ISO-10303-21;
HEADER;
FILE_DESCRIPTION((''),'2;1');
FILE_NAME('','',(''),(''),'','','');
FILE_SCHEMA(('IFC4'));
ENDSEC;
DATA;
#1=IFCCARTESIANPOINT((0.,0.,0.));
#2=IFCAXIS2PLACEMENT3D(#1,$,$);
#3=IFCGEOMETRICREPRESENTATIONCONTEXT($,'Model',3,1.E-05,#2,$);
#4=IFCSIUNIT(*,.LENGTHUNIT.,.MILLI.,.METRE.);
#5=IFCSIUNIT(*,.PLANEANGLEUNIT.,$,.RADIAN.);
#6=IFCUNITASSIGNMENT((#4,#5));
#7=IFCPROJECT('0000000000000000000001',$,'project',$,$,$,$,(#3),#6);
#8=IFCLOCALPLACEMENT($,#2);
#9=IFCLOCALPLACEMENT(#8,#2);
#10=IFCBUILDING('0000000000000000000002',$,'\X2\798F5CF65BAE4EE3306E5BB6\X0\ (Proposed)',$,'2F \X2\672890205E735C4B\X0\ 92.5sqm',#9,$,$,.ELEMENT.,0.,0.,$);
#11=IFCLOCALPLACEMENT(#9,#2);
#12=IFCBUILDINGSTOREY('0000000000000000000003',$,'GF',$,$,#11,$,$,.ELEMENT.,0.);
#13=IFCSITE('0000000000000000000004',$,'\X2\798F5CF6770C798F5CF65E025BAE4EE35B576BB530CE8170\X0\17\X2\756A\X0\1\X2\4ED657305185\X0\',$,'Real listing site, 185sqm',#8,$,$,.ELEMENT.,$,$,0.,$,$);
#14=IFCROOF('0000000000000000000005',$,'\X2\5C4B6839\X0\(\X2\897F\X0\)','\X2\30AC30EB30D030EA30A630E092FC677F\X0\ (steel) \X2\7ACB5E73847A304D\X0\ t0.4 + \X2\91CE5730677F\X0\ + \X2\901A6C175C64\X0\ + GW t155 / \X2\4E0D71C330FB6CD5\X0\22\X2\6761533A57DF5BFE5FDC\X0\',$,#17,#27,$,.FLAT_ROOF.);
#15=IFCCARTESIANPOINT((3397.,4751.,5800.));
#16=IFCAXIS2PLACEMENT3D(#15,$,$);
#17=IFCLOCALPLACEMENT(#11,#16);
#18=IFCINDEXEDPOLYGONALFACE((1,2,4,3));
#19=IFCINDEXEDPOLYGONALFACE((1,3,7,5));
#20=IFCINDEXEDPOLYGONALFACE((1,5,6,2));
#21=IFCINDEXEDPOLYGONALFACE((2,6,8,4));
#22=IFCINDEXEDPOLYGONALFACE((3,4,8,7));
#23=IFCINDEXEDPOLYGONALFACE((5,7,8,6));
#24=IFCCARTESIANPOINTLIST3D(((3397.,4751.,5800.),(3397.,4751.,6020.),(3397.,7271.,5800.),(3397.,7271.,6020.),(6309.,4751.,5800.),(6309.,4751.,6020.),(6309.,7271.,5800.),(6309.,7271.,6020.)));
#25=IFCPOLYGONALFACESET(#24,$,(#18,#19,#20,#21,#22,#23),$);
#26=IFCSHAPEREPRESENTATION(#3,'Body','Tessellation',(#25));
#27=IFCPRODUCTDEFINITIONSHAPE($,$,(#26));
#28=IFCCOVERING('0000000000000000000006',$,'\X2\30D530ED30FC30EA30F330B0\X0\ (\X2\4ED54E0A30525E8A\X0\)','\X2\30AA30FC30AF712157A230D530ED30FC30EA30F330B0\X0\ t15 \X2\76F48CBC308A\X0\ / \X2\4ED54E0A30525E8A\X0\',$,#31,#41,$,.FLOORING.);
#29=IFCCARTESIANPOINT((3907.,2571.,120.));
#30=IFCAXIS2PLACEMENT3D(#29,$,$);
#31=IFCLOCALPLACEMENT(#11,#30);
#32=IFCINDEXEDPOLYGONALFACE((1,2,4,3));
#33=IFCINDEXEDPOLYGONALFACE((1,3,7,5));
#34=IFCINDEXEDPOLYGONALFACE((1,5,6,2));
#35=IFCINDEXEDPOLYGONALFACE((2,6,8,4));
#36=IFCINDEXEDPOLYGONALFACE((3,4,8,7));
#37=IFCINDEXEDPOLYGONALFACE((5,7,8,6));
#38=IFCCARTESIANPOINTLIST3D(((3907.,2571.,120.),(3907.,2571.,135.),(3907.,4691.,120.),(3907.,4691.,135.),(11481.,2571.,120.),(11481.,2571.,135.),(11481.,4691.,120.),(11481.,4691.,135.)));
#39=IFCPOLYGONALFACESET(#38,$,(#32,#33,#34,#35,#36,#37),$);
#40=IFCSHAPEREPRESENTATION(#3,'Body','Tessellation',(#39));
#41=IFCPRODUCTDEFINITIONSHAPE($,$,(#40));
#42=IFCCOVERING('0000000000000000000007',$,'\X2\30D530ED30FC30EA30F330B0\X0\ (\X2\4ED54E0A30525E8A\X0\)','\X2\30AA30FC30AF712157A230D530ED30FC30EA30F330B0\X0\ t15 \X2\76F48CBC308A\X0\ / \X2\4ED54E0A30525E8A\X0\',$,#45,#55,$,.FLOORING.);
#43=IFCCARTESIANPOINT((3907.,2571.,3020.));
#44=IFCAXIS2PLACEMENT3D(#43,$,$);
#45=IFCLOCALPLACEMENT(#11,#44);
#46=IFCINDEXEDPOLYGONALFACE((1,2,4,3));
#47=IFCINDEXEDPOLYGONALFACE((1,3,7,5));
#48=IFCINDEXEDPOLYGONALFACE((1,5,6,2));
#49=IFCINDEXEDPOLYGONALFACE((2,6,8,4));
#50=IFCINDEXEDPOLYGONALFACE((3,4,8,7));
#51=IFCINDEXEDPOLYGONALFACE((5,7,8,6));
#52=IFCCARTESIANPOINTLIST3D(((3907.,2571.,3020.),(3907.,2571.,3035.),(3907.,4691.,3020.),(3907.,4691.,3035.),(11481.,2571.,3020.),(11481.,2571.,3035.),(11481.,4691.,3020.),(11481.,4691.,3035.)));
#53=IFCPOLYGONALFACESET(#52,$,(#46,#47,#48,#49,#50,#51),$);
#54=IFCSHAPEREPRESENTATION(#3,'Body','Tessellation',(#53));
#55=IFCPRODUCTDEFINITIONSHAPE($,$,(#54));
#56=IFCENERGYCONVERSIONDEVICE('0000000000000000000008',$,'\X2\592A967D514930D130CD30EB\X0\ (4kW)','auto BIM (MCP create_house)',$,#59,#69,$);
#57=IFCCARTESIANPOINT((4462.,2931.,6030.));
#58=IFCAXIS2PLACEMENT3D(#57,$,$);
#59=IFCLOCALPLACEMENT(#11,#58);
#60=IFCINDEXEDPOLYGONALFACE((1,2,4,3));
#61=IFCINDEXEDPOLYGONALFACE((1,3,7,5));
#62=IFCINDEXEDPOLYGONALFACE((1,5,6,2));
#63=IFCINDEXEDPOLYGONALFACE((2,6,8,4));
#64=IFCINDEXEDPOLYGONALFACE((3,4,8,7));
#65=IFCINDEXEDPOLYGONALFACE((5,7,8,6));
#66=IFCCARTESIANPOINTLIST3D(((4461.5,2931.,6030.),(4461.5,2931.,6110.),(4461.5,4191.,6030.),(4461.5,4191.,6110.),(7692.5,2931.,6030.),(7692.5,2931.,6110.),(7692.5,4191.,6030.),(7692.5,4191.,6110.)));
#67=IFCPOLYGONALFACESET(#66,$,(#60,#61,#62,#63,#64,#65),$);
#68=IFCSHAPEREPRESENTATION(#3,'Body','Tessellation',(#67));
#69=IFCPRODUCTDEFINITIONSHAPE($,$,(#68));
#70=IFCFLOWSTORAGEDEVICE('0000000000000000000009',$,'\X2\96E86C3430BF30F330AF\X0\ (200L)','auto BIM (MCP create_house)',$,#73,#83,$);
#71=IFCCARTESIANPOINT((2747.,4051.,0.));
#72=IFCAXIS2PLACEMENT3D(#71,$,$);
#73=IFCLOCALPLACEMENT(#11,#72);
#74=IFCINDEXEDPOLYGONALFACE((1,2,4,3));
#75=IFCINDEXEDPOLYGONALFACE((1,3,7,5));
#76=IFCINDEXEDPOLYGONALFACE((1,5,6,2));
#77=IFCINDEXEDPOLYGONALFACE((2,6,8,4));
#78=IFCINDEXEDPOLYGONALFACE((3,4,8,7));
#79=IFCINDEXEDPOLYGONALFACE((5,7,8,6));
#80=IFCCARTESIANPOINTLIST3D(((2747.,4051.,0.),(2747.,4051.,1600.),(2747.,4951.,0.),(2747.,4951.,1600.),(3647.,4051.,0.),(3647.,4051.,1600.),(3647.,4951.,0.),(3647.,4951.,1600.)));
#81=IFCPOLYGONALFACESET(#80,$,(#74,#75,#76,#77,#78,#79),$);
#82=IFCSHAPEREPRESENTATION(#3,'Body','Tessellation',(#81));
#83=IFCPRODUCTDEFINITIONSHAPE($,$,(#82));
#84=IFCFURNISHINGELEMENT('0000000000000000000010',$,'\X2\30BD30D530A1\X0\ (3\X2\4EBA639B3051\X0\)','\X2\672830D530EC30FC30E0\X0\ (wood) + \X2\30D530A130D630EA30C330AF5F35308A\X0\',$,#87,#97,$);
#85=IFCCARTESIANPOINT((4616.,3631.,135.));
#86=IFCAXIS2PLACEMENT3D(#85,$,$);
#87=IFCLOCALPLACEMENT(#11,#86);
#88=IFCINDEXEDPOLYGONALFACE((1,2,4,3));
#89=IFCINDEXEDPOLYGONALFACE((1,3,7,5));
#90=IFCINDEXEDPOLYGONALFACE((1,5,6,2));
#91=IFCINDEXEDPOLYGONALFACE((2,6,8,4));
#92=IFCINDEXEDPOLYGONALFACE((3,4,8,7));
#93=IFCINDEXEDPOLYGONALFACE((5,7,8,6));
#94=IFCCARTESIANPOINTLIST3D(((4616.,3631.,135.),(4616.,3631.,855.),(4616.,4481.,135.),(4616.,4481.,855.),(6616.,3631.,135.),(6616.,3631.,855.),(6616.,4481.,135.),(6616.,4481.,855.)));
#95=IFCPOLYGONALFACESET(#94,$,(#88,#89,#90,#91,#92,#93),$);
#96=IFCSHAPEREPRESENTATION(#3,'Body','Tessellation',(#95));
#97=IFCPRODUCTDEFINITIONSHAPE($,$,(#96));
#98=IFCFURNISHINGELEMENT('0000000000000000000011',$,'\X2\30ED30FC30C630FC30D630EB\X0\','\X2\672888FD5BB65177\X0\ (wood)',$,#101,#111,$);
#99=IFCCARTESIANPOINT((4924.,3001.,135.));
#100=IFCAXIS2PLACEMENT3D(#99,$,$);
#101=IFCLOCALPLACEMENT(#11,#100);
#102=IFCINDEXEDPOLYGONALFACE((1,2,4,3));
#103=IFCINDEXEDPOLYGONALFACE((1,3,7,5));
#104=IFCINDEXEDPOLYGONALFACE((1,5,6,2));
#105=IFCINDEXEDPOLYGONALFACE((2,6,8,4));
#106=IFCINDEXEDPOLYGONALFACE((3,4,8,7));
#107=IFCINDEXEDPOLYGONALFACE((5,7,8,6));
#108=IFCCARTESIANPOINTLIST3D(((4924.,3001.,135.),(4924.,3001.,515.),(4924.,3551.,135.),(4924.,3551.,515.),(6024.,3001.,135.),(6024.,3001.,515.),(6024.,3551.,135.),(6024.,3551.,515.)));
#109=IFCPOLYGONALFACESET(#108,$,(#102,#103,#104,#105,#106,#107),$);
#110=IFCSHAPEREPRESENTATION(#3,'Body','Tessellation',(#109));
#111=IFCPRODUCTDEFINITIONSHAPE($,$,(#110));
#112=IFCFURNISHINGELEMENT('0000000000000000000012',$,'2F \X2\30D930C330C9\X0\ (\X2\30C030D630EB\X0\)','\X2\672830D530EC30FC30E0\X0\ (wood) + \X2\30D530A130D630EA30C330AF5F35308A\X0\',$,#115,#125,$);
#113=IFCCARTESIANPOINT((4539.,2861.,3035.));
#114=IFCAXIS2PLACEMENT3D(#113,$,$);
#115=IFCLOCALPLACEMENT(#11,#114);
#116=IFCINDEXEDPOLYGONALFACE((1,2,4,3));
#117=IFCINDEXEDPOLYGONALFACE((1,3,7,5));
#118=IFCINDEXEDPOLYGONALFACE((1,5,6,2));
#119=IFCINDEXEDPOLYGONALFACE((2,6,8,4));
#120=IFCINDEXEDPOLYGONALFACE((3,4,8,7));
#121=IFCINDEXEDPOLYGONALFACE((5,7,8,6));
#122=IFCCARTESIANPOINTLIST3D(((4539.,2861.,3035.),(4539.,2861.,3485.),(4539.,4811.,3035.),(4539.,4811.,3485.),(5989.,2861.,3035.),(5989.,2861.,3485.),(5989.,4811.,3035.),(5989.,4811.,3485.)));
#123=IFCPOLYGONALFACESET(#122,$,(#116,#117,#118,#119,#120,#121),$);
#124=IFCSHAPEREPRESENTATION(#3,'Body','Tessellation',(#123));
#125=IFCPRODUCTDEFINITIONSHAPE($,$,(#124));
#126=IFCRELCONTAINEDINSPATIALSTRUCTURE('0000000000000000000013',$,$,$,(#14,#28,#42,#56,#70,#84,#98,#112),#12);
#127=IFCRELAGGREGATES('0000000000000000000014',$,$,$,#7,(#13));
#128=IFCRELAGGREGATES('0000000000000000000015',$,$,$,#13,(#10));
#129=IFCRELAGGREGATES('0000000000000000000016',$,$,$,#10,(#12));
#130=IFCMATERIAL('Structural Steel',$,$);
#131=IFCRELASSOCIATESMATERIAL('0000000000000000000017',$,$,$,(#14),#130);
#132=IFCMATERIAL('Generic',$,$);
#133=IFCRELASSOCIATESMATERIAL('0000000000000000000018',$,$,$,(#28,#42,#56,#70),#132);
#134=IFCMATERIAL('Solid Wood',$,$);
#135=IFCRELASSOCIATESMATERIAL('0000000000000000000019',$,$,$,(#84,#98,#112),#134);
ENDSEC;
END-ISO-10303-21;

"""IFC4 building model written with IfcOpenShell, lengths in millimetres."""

from ifc_helpers import new_model, si_unit, frame, frame_2d, origin, place, context, project, spatial, rectangle, extrude, material, element, save


model = new_model("IFC4")

# Units and contexts
model_context = context("Model", 3, precision=1e-05, world=origin())
ifc_project = project(units=[si_unit("LENGTHUNIT", "METRE", prefix="MILLI"), si_unit("PLANEANGLEUNIT", "RADIAN")], contexts=[model_context])

# Site, building, storey
site_placement = place(None, origin())
site = spatial("IfcSite", under=ifc_project, at=site_placement, Name="福島県福島市宮代字段ノ腰17番1他地内", ObjectType="Real listing site, 185sqm", CompositionType="ELEMENT", RefElevation=0.0)
building_placement = place(site_placement, origin())
building = spatial("IfcBuilding", under=site, at=building_placement, Name="福島宮代の家 (Proposed)", ObjectType="2F 木造平屋 92.5sqm", CompositionType="ELEMENT", ElevationOfRefHeight=0.0, ElevationOfTerrain=0.0)
storey_placement = place(building_placement, origin())
storey = spatial("IfcBuildingStorey", under=building, at=storey_placement, Name="GF", CompositionType="ELEMENT", Elevation=0.0)

# Shared definitions
ifc_material_1 = material(Name="Solid Wood")

# Roof
ifc_material_2 = material(Name="Structural Steel")
roof_1_placement = place(storey_placement, frame((3397.0, 4751.0, 5800.0)))
element("IfcRoof", 1, at=roof_1_placement, inside=storey, material=ifc_material_2, Name="屋根(西)", Description="ガルバリウム鋼板 (steel) 立平葺き t0.4 + 野地板 + 通気層 + GW t155 / 不燃・法22条区域対応", PredefinedType="FLAT_ROOF", context=model_context, shape_type="SweptSolid", body=[
    extrude(rectangle(XDim=2912.0, YDim=2520.0, at=frame_2d((1456.0, 1260.0))), frame((3397.0, 4751.0, 5800.0)), (0.0, 0.0, 1.0), 220.0),
])

# Coverings
ifc_material_3 = material(Name="Generic")
covering_1_placement = place(storey_placement, frame((3907.0, 2571.0, 120.0)))
element("IfcCovering", 2, at=covering_1_placement, inside=storey, material=ifc_material_3, Name="フローリング (仕上げ床)", Description="オーク無垢フローリング t15 直貼り / 仕上げ床", PredefinedType="FLOORING", context=model_context, shape_type="SweptSolid", body=[
    extrude(rectangle(XDim=7574.0, YDim=2120.0, at=frame_2d((3787.0, 1060.0))), frame((3907.0, 2571.0, 120.0)), (0.0, 0.0, 1.0), 15.0),
])
covering_2_placement = place(storey_placement, frame((3907.0, 2571.0, 3020.0)))
element("IfcCovering", 3, at=covering_2_placement, inside=storey, material=ifc_material_3, Name="フローリング (仕上げ床)", Description="オーク無垢フローリング t15 直貼り / 仕上げ床", PredefinedType="FLOORING", context=model_context, shape_type="SweptSolid", body=[
    extrude(rectangle(XDim=7574.0, YDim=2120.0, at=frame_2d((3787.0, 1060.0))), frame((3907.0, 2571.0, 3020.0)), (0.0, 0.0, 1.0), 15.0),
])

# Energy conversion device
energy_conversion_device_placement = place(storey_placement, frame((4462.0, 2931.0, 6030.0)))
element("IfcEnergyConversionDevice", 4, at=energy_conversion_device_placement, inside=storey, material=ifc_material_3, Name="太陽光パネル (4kW)", Description="auto BIM (MCP create_house)", context=model_context, shape_type="SweptSolid", body=[
    extrude(rectangle(XDim=3231.0, YDim=1260.0, at=frame_2d((1615.0, 630.0))), frame((4462.0, 2931.0, 6030.0)), (0.0, 0.0, 1.0), 80.0),
])

# Flow storage device
flow_storage_device_placement = place(storey_placement, frame((2747.0, 4051.0, 0.0)))
element("IfcFlowStorageDevice", 5, at=flow_storage_device_placement, inside=storey, material=ifc_material_3, Name="雨水タンク (200L)", Description="auto BIM (MCP create_house)", context=model_context, shape_type="SweptSolid", body=[
    extrude(rectangle(XDim=900.0, YDim=900.0, at=frame_2d((450.0, 450.0))), frame((2747.0, 4051.0, 0.0)), (0.0, 0.0, 1.0), 1600.0),
])

# Furnishing elements
furnishing_1_placement = place(storey_placement, frame((4616.0, 3631.0, 135.0)))
element("IfcFurnishingElement", 6, at=furnishing_1_placement, inside=storey, material=ifc_material_1, Name="ソファ (3人掛け)", Description="木フレーム (wood) + ファブリック張り", context=model_context, shape_type="SweptSolid", body=[
    extrude(rectangle(XDim=2000.0, YDim=850.0, at=frame_2d((1000.0, 425.0))), frame((4616.0, 3631.0, 135.0)), (0.0, 0.0, 1.0), 720.0),
])
furnishing_2_placement = place(storey_placement, frame((4924.0, 3001.0, 135.0)))
element("IfcFurnishingElement", 7, at=furnishing_2_placement, inside=storey, material=ifc_material_1, Name="ローテーブル", Description="木製家具 (wood)", context=model_context, shape_type="SweptSolid", body=[
    extrude(rectangle(XDim=1100.0, YDim=550.0, at=frame_2d((550.0, 275.0))), frame((4924.0, 3001.0, 135.0)), (0.0, 0.0, 1.0), 380.0),
])
furnishing_3_placement = place(storey_placement, frame((4539.0, 2861.0, 3035.0)))
element("IfcFurnishingElement", 8, at=furnishing_3_placement, inside=storey, material=ifc_material_1, Name="2F ベッド (ダブル)", Description="木フレーム (wood) + ファブリック張り", context=model_context, shape_type="SweptSolid", body=[
    extrude(rectangle(XDim=1450.0, YDim=1950.0, at=frame_2d((725.0, 975.0))), frame((4539.0, 2861.0, 3035.0)), (0.0, 0.0, 1.0), 450.0),
])

save(model, "model.ifc")
